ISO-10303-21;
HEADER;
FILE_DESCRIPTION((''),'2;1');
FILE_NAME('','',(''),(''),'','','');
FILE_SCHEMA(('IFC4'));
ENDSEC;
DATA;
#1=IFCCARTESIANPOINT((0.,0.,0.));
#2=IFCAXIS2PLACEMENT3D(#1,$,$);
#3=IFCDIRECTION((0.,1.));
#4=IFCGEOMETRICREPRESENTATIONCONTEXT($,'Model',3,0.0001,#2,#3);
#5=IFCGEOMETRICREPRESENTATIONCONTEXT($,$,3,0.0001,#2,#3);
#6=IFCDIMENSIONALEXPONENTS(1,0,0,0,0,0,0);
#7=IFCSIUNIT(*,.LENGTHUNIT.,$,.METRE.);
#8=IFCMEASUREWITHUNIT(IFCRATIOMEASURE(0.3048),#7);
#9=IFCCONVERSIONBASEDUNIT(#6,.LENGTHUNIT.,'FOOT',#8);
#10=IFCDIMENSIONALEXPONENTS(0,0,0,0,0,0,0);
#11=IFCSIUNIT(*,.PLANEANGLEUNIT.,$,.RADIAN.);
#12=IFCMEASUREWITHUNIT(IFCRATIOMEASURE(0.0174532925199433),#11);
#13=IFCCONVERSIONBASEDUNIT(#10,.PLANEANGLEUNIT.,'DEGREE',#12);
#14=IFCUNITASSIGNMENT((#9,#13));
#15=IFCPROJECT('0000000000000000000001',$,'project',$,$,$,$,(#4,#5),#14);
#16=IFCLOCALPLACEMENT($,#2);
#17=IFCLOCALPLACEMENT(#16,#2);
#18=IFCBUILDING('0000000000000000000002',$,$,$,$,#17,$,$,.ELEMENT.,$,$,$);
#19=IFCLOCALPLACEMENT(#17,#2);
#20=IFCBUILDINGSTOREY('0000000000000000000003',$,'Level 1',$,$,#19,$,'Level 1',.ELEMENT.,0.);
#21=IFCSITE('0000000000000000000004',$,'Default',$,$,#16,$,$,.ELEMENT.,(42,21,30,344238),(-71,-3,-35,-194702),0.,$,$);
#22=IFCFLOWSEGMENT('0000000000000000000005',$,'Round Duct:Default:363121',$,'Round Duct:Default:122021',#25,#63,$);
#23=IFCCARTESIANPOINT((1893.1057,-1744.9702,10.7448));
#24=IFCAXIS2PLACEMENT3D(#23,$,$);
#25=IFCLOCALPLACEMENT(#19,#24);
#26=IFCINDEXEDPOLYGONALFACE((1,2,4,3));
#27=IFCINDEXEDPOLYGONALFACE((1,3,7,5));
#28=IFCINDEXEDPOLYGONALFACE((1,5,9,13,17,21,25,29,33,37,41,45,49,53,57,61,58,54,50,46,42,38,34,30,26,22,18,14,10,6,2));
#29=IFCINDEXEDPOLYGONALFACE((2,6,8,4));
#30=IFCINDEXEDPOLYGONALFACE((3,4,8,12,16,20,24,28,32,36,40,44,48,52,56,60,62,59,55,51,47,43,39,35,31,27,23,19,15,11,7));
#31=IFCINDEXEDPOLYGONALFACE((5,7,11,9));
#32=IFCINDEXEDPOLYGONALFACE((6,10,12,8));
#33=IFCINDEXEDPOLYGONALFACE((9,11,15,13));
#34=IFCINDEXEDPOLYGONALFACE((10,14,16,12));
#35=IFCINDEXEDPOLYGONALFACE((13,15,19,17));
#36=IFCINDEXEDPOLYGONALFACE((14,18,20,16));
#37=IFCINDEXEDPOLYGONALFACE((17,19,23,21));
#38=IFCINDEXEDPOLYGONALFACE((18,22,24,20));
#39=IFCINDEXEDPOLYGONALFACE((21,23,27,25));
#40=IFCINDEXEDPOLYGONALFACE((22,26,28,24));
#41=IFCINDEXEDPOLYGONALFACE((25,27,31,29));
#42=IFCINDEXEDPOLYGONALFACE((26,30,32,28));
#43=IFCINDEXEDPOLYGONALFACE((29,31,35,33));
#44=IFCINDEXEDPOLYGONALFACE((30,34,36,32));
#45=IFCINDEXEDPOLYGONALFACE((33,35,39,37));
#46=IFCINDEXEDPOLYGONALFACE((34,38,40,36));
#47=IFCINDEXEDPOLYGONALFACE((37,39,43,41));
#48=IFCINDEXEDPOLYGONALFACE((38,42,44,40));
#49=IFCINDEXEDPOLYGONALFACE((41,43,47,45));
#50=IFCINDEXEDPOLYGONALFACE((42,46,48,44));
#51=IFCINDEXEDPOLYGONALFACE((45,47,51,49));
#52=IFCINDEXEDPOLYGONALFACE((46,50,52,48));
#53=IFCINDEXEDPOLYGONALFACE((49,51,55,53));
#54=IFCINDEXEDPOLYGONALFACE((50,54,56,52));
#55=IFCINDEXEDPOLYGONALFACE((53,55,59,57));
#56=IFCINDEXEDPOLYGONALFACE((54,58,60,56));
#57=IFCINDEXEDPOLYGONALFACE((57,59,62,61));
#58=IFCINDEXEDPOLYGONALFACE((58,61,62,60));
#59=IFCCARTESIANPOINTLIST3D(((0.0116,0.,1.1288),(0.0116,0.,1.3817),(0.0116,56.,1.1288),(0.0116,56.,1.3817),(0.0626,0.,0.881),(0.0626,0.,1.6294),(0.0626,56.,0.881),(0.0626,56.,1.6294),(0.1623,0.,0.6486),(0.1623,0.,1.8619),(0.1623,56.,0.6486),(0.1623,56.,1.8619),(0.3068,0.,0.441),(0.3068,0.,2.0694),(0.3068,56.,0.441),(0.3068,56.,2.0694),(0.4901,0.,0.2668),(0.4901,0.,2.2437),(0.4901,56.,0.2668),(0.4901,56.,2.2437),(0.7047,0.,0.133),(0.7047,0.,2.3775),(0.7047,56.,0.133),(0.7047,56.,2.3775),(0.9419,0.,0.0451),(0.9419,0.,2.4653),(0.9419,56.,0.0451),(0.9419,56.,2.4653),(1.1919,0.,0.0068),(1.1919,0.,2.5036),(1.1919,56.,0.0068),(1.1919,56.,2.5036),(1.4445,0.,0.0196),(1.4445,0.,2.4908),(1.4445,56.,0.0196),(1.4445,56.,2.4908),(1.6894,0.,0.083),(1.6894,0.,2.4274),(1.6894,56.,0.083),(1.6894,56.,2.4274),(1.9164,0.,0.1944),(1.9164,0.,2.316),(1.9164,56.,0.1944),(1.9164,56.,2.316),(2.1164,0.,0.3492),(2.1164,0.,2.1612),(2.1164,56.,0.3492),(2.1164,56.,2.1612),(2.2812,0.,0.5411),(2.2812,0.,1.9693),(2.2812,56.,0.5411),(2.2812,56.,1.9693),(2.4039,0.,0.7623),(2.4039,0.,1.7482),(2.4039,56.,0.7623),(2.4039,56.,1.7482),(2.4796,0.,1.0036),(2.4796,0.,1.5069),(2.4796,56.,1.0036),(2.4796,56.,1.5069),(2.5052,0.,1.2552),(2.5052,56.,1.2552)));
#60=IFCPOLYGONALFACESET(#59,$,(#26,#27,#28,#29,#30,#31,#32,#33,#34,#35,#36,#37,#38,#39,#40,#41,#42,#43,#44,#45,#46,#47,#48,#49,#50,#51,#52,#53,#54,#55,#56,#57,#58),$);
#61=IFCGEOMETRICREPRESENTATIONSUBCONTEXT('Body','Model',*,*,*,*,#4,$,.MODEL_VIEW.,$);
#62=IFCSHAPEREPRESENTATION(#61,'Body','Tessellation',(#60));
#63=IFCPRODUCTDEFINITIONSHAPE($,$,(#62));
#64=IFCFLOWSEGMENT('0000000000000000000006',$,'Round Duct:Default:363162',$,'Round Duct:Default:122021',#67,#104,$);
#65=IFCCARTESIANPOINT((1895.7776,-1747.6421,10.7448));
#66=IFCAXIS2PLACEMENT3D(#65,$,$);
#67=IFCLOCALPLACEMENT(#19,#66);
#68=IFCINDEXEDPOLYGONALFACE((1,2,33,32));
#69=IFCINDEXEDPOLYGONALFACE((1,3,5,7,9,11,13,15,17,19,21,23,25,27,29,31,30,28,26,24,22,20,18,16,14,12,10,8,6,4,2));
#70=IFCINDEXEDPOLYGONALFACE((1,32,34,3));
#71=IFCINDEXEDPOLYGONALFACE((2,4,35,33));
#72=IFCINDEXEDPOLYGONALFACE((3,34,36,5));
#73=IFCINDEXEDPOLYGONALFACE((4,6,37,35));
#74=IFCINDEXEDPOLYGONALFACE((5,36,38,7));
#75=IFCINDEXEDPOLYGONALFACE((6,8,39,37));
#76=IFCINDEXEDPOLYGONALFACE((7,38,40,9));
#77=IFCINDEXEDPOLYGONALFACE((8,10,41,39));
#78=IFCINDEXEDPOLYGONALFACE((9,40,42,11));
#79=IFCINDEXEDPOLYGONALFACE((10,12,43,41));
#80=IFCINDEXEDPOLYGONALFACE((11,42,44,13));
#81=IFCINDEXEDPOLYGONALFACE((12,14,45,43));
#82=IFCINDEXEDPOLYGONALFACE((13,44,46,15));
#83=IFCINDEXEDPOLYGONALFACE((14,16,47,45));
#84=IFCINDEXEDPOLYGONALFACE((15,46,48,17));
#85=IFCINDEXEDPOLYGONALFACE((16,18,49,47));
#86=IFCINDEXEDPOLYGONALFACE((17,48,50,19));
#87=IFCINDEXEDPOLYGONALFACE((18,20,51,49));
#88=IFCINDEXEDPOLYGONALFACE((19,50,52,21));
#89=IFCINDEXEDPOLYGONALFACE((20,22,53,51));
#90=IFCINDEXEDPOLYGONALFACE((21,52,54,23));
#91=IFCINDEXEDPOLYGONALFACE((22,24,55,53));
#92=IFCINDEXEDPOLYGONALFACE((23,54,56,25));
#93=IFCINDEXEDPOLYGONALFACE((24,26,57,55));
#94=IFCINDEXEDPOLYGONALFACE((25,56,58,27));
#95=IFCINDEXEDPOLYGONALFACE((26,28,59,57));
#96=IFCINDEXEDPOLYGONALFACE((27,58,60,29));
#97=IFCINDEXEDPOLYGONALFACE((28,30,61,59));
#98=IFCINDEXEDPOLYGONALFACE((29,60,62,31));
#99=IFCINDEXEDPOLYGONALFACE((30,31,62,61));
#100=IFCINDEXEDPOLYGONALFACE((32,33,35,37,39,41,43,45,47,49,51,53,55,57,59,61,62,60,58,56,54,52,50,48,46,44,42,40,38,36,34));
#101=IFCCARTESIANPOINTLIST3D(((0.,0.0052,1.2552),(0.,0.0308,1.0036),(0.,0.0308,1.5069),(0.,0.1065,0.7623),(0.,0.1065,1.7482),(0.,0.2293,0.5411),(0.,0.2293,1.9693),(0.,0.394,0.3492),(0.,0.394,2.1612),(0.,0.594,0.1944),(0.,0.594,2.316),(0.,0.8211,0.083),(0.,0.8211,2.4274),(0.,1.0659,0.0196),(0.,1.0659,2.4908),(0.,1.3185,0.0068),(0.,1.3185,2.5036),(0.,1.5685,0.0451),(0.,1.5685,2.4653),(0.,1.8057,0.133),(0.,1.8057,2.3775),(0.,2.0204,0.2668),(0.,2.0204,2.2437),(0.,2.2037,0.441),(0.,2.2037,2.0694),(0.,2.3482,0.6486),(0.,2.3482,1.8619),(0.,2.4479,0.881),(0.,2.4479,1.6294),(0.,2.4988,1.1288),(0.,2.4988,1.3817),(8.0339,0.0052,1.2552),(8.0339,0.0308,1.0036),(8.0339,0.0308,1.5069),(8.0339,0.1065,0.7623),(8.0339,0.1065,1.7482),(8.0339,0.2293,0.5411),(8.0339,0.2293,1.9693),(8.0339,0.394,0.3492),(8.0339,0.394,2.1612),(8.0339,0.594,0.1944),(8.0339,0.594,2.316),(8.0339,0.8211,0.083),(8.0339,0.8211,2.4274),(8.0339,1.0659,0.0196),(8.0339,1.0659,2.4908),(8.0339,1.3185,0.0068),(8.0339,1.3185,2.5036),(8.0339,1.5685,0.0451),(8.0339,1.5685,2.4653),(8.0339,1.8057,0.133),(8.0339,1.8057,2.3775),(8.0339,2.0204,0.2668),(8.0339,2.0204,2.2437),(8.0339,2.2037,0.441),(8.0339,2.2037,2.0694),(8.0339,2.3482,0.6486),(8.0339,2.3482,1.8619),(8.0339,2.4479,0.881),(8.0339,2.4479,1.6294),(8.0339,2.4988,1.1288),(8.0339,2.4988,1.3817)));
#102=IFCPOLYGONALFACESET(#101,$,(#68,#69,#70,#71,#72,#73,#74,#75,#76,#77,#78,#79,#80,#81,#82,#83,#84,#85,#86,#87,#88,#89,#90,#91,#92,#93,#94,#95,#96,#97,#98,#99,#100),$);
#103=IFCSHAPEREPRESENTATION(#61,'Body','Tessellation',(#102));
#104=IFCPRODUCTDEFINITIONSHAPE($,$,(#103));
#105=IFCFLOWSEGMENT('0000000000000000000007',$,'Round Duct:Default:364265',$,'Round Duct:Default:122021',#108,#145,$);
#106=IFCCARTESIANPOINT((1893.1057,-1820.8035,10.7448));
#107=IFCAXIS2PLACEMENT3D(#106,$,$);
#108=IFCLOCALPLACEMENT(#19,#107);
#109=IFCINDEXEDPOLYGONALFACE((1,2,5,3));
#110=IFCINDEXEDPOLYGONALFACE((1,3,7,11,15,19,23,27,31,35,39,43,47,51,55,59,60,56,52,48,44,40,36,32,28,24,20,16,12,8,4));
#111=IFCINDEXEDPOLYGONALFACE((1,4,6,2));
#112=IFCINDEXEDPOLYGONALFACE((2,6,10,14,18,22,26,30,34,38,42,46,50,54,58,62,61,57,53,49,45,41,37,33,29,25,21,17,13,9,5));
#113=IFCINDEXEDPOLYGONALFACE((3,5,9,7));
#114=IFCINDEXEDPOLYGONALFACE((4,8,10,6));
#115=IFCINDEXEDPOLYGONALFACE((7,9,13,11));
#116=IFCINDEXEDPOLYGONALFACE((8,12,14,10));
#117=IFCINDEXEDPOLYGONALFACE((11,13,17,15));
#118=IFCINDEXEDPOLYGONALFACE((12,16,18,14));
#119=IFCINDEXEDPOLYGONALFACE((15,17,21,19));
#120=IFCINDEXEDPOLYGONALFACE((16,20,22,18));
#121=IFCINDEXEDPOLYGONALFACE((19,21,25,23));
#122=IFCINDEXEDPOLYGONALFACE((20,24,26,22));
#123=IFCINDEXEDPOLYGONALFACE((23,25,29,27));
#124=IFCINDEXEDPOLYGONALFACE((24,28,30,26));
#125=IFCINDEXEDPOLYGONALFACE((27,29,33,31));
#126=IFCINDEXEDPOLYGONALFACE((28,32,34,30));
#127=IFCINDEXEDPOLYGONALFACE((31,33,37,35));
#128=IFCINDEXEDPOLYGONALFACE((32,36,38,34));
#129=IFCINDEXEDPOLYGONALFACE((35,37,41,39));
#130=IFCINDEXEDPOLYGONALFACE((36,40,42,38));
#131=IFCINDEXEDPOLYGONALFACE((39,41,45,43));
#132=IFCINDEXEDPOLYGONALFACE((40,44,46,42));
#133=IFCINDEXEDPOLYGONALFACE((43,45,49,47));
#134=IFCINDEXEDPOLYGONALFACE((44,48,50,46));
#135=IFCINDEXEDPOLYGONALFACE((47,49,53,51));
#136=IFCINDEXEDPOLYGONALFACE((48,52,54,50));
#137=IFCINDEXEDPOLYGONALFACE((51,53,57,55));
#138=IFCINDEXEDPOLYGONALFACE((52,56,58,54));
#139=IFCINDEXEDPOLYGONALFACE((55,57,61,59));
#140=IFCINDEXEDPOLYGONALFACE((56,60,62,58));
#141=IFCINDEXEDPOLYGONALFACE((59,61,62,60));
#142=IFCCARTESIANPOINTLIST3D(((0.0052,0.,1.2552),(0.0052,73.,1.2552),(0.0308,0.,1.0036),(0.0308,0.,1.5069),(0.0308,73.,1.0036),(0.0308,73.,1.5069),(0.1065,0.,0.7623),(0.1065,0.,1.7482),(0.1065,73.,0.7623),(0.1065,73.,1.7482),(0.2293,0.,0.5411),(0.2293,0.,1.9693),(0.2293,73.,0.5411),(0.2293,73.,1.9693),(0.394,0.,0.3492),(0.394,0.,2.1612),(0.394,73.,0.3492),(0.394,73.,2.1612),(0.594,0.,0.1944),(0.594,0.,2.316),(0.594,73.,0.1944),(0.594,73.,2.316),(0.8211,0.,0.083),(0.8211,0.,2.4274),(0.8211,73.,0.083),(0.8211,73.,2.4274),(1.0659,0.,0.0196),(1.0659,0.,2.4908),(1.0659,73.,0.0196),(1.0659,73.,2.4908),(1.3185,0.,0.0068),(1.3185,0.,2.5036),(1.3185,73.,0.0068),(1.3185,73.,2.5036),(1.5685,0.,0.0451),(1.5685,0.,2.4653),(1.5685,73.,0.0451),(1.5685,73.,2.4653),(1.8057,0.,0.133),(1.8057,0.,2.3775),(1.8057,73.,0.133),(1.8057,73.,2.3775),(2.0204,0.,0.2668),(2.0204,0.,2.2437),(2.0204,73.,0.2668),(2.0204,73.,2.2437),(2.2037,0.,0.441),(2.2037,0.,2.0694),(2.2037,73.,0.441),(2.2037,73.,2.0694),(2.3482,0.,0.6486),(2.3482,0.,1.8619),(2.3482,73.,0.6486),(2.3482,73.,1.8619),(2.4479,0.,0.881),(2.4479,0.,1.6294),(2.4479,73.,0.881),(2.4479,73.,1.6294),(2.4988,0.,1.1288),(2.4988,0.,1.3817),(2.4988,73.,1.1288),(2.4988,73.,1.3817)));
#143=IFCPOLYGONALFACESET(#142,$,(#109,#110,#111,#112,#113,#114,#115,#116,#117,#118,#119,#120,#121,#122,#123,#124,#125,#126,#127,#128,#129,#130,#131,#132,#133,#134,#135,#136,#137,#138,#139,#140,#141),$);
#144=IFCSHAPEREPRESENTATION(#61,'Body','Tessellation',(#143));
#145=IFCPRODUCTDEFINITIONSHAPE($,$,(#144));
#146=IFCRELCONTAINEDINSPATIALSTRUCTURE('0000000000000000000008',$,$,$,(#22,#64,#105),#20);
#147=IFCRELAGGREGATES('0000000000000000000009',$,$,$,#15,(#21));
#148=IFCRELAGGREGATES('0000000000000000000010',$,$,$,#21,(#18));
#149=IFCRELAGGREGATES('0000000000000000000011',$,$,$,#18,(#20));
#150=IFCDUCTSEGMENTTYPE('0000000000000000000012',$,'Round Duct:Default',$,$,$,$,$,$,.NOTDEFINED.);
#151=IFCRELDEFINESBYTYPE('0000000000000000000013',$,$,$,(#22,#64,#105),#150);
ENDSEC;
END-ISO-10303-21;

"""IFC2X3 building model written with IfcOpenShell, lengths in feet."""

from ifc_helpers import new_model, entity, si_unit, converted_unit, direction, frame, frame_2d, origin, origin_2d_with_axis, place, context, subcontext, project, spatial, circle, extrude, type_object, element, save


model = new_model("IFC2X3")

# Units and contexts
model_context = context("Model", 3, precision=0.0001, world=origin(), true_north=direction((0.0, 1.0)))
context_of_model = context(None, 3, precision=0.0001, world=origin(), true_north=direction((0.0, 1.0)))
body_context = subcontext(model_context, "Body", "Model", "MODEL_VIEW")
ifc_project = project(units=[converted_unit("LENGTHUNIT", "FOOT", entity("IfcRatioMeasure", 0.3048), si_unit("LENGTHUNIT", "METRE"), dimensions=[1, 0, 0, 0, 0, 0, 0]), converted_unit("PLANEANGLEUNIT", "DEGREE", entity("IfcRatioMeasure", 0.0174532925199433), si_unit("PLANEANGLEUNIT", "RADIAN"), dimensions=[0, 0, 0, 0, 0, 0, 0])], contexts=[model_context, context_of_model])

# Site, building, storey
site_placement = place(None, origin())
site = spatial("IfcSite", under=ifc_project, at=site_placement, Name="Default", CompositionType="ELEMENT", RefLatitude=(42, 21, 30, 344238), RefLongitude=(-71, -3, -35, -194702), RefElevation=0.0)
building_placement = place(site_placement, origin())
building = spatial("IfcBuilding", under=site, at=building_placement, CompositionType="ELEMENT")
storey_placement = place(building_placement, origin())
storey = spatial("IfcBuildingStorey", under=building, at=storey_placement, Name="Level 1", LongName="Level 1", CompositionType="ELEMENT", Elevation=0.0)

# Flow segments
duct_segment_type = type_object("IfcDuctSegmentType", Name="Round Duct:Default", PredefinedType="NOTDEFINED")
flow_segment_1_placement = place(storey_placement, frame((1893.1057, -1744.9702, 10.7448)))
element("IfcFlowSegment", 1, at=flow_segment_1_placement, inside=storey, type_object=duct_segment_type, Name="Round Duct:Default:363121", ObjectType="Round Duct:Default:122021", context=body_context, shape_type="SweptSolid", body=[
    extrude(circle(Radius=1.25, at=origin_2d_with_axis()), frame((1.2552, 0.0, 1.2552), z_axis=(0.0, 1.0, 0.0), x_axis=(1.0, 0.0, 0.0)), (0.0, 0.0, 1.0), 56.0),
])
flow_segment_2_placement = place(storey_placement, frame((1895.7776, -1747.6421, 10.7448)))
element("IfcFlowSegment", 2, at=flow_segment_2_placement, inside=storey, type_object=duct_segment_type, Name="Round Duct:Default:363162", ObjectType="Round Duct:Default:122021", context=body_context, shape_type="SweptSolid", body=[
    extrude(circle(Radius=1.25, at=origin_2d_with_axis()), frame((0.0, 1.2552, 1.2552), z_axis=(1.0, 0.0, 0.0), x_axis=(0.0, -1.0, 0.0)), (0.0, 0.0, 1.0), 8.0339),
])
flow_segment_3_placement = place(storey_placement, frame((1893.1057, -1820.8035, 10.7448)))
element("IfcFlowSegment", 3, at=flow_segment_3_placement, inside=storey, type_object=duct_segment_type, Name="Round Duct:Default:364265", ObjectType="Round Duct:Default:122021", context=body_context, shape_type="SweptSolid", body=[
    extrude(circle(Radius=1.25, at=frame_2d((0.0, 0.0), x_axis=(1.0, 0.0))), frame((1.2552, 0.0, 1.2552), z_axis=(0.0, 1.0, 0.0), x_axis=(-1.0, 0.0, 0.0)), (0.0, 0.0, 1.0), 73.0),
])

save(model, "model.ifc")
